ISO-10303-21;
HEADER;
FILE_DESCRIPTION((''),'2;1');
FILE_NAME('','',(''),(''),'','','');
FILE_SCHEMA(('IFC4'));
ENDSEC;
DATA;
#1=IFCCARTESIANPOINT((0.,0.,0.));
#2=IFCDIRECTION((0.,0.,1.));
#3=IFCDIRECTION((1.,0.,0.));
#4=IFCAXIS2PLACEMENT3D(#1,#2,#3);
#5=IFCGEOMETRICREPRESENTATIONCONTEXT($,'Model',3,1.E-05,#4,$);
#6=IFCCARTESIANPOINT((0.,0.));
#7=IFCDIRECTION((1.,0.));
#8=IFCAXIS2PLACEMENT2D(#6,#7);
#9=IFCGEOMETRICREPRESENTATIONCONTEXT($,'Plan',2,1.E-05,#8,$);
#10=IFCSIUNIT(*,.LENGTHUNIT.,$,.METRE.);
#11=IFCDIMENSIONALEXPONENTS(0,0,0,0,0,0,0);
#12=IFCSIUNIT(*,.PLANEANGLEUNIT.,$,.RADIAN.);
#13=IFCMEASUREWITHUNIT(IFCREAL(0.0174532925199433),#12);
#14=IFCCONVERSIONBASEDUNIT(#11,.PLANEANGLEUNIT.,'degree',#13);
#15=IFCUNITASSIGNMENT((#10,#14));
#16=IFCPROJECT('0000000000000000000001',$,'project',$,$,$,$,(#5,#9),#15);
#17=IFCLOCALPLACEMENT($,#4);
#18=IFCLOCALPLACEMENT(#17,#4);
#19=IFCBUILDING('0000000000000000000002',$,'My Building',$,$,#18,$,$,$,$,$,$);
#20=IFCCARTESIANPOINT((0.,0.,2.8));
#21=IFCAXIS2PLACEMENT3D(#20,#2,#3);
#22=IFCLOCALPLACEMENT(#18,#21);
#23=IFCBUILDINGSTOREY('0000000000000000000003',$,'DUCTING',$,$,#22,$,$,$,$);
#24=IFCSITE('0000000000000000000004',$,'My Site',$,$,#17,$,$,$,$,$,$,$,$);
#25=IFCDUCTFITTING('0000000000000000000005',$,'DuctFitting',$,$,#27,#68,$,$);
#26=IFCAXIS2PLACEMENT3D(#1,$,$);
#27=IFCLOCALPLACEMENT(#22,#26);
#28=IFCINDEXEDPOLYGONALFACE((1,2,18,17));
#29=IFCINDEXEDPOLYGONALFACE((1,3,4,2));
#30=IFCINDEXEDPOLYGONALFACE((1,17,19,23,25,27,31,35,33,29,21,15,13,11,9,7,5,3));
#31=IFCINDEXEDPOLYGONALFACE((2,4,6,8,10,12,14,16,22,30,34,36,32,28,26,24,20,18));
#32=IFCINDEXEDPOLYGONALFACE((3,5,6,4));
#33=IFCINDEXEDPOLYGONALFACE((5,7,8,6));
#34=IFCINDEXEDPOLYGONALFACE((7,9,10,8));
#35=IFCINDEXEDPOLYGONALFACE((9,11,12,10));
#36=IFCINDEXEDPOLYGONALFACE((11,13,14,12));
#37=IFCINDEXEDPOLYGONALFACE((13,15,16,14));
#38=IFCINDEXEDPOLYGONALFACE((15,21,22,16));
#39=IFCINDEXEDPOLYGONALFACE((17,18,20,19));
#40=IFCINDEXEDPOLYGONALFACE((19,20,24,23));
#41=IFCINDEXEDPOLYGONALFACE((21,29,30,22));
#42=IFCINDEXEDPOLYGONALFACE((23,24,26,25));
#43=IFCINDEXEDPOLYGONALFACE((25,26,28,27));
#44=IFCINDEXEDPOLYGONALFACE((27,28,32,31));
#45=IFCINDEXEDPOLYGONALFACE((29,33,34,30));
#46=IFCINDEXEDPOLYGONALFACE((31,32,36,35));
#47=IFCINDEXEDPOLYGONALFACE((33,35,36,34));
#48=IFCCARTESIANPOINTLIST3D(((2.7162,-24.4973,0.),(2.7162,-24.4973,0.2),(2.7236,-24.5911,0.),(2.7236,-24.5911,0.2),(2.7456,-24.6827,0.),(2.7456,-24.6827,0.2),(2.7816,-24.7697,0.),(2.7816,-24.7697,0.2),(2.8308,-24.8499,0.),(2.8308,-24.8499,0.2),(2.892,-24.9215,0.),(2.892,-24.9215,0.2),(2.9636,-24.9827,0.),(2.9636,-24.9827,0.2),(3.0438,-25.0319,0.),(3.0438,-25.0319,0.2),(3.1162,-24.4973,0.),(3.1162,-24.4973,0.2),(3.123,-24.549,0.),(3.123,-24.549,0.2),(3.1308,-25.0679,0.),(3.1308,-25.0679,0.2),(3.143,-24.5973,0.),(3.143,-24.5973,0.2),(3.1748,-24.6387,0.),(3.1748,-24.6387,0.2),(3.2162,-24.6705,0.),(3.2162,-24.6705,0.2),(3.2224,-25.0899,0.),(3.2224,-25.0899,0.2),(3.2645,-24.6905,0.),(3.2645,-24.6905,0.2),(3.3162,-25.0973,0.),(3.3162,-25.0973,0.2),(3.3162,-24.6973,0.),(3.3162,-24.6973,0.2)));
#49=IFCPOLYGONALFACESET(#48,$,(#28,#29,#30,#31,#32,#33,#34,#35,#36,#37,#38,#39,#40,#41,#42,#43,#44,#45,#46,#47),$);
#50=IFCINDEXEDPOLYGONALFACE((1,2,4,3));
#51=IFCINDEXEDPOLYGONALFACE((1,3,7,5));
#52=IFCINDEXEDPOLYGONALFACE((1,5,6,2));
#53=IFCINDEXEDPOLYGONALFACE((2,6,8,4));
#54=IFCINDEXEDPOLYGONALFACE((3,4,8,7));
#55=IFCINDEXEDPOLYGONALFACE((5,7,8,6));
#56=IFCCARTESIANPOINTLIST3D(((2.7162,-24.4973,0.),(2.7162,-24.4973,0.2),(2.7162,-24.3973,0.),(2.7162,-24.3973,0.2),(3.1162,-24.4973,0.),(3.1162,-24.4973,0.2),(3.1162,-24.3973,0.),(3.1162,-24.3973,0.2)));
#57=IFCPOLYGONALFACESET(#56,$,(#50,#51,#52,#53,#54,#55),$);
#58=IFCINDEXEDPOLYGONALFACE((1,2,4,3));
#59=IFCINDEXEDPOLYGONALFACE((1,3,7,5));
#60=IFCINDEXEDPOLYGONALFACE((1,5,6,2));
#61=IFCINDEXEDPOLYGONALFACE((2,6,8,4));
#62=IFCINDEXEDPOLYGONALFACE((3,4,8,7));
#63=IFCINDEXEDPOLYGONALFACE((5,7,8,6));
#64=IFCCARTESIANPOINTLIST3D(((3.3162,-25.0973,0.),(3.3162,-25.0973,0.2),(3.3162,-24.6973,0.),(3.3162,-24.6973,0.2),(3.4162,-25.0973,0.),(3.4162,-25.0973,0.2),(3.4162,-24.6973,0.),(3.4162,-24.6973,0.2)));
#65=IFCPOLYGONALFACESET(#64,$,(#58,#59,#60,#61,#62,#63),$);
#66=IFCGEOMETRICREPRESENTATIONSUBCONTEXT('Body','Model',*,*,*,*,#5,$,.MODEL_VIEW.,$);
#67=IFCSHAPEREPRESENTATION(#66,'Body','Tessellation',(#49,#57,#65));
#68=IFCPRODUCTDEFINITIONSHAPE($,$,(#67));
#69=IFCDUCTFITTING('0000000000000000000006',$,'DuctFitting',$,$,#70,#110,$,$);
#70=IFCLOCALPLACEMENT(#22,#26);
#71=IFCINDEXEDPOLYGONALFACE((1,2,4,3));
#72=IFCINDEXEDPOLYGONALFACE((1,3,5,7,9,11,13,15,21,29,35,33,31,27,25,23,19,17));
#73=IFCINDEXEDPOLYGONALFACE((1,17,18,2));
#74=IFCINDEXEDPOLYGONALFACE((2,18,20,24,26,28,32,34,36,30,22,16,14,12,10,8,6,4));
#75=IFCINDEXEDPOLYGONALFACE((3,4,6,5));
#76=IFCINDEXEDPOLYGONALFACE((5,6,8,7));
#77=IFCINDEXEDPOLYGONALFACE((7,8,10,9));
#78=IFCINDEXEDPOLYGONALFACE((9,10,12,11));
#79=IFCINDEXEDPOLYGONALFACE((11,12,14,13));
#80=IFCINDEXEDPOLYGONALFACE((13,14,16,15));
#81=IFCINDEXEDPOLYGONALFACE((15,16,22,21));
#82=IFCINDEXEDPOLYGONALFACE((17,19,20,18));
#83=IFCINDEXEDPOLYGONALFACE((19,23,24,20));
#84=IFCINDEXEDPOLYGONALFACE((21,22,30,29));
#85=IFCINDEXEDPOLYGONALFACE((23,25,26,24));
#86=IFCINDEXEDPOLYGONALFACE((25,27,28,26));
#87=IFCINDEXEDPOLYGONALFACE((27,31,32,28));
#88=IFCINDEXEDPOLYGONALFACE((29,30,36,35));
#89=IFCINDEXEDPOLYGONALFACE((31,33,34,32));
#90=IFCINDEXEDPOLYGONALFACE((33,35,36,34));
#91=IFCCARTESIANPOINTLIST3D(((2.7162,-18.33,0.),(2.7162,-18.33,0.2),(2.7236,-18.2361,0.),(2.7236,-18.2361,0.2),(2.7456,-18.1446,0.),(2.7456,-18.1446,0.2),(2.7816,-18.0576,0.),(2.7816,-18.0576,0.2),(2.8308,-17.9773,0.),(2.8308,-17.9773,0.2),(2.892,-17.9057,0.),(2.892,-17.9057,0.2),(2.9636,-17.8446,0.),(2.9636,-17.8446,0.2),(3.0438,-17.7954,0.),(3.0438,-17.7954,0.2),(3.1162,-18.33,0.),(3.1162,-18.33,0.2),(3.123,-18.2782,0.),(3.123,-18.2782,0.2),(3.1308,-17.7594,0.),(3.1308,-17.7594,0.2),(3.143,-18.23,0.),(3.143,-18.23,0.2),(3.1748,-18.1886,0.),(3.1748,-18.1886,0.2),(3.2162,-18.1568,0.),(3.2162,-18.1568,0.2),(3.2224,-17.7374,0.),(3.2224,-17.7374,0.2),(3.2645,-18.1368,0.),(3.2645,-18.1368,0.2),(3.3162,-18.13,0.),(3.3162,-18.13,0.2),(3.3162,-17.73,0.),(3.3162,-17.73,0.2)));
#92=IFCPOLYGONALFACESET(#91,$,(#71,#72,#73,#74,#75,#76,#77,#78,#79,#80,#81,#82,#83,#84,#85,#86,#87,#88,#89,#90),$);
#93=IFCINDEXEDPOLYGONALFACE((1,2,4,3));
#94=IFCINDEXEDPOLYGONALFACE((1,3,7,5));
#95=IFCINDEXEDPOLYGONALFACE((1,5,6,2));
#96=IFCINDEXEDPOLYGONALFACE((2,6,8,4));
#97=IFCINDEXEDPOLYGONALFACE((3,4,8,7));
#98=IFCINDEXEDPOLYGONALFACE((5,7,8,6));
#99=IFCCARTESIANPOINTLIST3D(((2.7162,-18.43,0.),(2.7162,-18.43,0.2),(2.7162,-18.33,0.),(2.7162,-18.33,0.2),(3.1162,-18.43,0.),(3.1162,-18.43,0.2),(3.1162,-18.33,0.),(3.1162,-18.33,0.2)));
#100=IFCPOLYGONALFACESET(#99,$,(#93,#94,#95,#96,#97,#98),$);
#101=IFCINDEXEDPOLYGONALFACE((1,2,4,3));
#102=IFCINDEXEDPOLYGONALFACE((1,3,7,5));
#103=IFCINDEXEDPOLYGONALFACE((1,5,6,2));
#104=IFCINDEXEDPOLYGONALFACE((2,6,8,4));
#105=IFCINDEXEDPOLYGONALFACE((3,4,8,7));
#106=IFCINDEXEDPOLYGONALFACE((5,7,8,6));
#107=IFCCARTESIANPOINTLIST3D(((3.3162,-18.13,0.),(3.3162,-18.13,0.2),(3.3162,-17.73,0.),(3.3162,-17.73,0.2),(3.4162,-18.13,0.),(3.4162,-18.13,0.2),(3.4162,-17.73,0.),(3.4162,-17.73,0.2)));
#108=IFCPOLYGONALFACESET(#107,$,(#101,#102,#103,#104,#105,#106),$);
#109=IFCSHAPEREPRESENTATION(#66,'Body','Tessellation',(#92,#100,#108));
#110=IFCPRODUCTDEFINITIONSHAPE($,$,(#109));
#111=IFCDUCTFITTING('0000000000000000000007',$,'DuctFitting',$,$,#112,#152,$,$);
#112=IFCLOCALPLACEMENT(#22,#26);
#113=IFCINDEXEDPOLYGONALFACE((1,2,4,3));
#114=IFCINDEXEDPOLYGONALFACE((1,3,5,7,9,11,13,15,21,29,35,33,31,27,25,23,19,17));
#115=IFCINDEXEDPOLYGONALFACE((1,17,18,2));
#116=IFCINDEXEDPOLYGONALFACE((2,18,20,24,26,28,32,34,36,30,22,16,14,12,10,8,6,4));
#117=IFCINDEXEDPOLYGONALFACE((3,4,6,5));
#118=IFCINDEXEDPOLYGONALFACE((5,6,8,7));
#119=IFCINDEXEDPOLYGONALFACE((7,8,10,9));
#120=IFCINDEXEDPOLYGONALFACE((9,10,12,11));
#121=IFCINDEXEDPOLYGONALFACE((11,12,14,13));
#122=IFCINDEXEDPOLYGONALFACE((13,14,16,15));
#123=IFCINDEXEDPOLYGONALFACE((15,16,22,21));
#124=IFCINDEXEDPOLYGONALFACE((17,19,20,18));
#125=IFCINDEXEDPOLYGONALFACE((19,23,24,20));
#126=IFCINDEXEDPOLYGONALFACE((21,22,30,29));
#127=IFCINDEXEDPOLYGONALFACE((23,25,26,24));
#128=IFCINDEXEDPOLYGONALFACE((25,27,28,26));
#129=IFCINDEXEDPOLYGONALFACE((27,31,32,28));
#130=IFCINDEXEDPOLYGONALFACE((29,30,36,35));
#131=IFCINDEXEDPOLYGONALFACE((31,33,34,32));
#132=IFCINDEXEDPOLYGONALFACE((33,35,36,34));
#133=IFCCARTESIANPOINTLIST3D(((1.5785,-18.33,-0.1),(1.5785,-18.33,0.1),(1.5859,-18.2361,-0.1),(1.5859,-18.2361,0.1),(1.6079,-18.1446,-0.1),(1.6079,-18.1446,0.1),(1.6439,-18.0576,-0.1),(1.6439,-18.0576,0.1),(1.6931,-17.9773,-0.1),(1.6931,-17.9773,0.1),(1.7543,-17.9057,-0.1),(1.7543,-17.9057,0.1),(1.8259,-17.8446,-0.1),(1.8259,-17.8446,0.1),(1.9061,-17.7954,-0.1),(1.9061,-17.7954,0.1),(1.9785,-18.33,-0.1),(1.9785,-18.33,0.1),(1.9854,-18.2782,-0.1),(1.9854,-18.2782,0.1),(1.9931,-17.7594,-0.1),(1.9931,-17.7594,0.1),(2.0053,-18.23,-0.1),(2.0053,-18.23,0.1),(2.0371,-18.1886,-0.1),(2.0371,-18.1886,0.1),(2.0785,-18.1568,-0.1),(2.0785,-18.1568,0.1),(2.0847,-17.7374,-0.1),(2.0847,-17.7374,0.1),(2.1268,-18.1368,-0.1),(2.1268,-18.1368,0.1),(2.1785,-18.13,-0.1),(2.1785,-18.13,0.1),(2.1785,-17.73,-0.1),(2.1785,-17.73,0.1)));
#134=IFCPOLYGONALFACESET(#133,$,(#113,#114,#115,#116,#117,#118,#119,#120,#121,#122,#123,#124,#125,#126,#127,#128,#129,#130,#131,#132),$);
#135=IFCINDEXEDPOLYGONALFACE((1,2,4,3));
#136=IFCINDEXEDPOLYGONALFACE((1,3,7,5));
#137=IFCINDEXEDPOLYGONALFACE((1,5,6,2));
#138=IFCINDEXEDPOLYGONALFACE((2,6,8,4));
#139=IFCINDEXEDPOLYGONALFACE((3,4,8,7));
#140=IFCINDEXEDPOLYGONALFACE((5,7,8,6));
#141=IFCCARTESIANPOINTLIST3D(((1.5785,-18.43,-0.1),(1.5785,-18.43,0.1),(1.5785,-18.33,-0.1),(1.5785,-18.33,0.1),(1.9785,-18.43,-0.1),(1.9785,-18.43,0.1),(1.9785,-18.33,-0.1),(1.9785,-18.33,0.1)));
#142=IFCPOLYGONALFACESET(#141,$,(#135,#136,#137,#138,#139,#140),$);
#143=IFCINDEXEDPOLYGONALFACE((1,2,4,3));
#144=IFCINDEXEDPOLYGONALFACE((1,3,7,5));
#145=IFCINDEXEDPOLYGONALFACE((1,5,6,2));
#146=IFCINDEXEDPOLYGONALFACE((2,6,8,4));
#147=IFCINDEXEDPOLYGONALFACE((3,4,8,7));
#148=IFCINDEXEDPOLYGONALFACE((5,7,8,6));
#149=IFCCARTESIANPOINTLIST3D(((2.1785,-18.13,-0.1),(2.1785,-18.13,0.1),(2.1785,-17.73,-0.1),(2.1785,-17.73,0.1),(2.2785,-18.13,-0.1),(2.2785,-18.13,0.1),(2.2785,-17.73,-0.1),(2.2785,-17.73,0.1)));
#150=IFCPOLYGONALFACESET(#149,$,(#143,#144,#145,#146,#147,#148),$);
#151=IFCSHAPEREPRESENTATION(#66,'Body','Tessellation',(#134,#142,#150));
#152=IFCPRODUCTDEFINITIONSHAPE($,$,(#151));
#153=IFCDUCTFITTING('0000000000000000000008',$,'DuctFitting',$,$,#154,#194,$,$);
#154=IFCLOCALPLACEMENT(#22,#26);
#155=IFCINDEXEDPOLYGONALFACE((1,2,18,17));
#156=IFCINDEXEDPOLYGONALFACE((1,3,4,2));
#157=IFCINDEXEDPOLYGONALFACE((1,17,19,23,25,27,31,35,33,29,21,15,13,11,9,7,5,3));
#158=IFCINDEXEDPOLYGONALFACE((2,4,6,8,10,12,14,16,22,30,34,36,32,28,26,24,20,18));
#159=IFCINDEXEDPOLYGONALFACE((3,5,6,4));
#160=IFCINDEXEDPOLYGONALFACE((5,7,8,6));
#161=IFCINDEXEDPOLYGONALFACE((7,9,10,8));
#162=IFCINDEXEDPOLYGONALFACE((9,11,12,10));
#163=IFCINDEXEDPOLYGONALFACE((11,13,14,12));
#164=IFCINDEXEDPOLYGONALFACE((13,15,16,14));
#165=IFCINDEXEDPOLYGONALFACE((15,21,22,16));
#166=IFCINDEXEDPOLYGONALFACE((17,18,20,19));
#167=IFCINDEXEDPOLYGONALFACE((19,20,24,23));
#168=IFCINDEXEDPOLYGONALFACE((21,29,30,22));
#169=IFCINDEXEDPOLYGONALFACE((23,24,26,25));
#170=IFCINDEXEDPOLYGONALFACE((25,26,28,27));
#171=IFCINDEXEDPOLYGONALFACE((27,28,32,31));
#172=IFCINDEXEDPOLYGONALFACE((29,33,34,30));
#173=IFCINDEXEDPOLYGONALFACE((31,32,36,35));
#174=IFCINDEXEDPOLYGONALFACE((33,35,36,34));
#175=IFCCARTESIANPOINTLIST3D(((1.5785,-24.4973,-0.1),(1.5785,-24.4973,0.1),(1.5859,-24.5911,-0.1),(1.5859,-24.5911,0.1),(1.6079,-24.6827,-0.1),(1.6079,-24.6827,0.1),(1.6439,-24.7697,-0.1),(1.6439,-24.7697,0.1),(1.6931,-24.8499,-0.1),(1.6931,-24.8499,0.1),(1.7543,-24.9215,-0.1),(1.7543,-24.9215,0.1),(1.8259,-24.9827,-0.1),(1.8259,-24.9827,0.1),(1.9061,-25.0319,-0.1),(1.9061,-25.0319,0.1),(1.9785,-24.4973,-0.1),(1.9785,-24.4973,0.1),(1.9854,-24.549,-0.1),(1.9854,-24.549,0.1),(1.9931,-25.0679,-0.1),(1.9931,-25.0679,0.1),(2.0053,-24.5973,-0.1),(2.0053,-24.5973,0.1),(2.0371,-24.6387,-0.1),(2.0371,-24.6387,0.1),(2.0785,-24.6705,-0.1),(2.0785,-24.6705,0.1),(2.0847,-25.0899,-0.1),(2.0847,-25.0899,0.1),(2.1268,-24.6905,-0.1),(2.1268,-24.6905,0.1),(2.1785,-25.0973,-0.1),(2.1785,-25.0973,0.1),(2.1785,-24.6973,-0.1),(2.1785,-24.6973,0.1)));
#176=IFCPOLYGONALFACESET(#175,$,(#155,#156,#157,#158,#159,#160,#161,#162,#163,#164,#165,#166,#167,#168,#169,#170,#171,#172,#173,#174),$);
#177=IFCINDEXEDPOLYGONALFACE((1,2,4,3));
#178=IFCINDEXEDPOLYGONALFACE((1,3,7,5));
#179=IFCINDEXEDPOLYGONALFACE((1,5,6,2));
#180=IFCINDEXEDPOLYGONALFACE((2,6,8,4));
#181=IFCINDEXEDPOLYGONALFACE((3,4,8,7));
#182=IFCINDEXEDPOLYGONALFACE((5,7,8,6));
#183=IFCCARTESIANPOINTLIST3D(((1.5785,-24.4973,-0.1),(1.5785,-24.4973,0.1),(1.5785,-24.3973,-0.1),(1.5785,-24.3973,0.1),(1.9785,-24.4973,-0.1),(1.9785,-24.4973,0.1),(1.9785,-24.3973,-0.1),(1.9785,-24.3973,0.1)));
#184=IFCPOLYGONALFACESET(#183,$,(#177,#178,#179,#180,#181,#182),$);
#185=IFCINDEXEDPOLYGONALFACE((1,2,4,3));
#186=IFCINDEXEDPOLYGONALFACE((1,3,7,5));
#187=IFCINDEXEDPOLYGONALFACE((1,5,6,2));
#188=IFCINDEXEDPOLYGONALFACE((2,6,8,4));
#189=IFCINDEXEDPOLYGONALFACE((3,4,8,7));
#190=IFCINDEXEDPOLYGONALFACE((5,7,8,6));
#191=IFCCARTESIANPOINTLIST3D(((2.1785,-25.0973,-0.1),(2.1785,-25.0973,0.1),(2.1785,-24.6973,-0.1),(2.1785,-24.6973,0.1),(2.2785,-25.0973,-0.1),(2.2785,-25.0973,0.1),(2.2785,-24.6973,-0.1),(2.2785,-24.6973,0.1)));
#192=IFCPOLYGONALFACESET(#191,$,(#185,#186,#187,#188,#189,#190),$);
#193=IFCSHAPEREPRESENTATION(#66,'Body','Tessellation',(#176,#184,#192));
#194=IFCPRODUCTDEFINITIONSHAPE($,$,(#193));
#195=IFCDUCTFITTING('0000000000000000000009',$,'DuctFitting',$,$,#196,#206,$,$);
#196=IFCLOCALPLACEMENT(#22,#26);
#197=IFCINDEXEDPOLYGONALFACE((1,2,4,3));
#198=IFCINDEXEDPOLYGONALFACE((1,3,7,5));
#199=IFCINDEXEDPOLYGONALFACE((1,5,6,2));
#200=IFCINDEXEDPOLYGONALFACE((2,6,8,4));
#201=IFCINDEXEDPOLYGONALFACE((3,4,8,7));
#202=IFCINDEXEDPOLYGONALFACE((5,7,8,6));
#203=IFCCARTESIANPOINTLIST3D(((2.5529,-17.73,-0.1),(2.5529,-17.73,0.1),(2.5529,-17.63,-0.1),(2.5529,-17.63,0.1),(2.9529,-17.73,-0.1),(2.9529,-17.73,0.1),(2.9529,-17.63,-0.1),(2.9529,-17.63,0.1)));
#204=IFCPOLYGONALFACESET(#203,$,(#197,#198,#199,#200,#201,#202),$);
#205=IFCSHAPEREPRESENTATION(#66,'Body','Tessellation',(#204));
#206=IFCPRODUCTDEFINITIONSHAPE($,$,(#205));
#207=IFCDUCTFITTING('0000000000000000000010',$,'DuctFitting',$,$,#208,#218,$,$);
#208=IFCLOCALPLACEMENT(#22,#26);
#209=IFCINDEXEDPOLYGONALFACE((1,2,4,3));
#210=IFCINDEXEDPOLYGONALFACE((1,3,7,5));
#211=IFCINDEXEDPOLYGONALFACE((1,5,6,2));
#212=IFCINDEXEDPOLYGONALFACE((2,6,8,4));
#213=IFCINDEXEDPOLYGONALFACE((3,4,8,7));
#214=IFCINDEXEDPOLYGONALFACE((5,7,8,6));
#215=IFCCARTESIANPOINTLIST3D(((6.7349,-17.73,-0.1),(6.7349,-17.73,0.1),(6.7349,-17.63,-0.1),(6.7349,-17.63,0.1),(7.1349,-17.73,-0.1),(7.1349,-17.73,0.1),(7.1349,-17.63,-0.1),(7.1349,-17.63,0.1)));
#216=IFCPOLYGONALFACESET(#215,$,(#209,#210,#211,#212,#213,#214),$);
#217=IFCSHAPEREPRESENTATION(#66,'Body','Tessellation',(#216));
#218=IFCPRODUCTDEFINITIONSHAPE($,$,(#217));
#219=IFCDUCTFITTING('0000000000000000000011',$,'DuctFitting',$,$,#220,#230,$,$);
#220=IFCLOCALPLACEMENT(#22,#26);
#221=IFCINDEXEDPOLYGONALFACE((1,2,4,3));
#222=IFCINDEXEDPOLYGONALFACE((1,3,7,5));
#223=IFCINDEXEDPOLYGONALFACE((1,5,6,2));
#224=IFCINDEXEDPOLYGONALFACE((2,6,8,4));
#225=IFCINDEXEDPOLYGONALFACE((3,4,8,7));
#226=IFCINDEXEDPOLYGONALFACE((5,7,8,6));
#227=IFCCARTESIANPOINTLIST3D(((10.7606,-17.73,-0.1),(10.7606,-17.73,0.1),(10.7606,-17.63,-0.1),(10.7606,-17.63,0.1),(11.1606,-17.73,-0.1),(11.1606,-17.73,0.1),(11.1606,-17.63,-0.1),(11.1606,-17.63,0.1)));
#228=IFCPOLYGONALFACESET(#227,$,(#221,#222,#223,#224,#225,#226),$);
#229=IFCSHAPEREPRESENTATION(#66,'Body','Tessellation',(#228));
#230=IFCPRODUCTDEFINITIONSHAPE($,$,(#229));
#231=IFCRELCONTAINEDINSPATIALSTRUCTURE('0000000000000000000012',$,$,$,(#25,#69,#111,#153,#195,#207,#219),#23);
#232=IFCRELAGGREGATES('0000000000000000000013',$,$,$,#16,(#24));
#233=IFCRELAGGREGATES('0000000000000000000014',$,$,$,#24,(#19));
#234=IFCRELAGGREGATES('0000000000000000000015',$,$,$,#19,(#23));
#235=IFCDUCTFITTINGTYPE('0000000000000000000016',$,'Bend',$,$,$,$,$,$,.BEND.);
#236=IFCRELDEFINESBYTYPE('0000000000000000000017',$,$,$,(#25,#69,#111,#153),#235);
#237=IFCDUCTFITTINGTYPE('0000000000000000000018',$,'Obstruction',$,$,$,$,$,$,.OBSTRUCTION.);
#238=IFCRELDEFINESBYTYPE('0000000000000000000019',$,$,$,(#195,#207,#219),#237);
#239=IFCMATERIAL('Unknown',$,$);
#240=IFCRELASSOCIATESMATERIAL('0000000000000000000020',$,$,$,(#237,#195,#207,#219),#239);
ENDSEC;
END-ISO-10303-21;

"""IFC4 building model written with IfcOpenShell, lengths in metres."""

from ifc_helpers import new_model, entity, si_unit, converted_unit, frame, origin_with_axes, origin_2d_with_axis, place, context, subcontext, project, spatial, line, arc, indexed_curve, rectangle, outline, extrude, source, transform, mapped, material, material_profile, profile_set, profile_usage, type_object, type_shapes, element, save


model = new_model("IFC4")

# Units and contexts
model_context = context("Model", 3, precision=1e-05, world=origin_with_axes())
plan_context = context("Plan", 2, precision=1e-05, world=origin_2d_with_axis())
body_context = subcontext(model_context, "Body", "Model", "MODEL_VIEW")
ifc_project = project(units=[si_unit("LENGTHUNIT", "METRE"), converted_unit("PLANEANGLEUNIT", "degree", entity("IfcReal", 0.0174532925199433), si_unit("PLANEANGLEUNIT", "RADIAN"), dimensions=[0, 0, 0, 0, 0, 0, 0])], contexts=[model_context, plan_context])

# Site, building, storey
site_placement = place(None, origin_with_axes())
site = spatial("IfcSite", under=ifc_project, at=site_placement, Name="My Site")
building_placement = place(site_placement, origin_with_axes())
building = spatial("IfcBuilding", under=site, at=building_placement, Name="My Building")
storey_placement = place(building_placement, frame((0.0, 0.0, 2.8), z_axis=(0.0, 0.0, 1.0), x_axis=(1.0, 0.0, 0.0)))
storey = spatial("IfcBuildingStorey", under=building, at=storey_placement, Name="DUCTING")

# Shared definitions
ifc_material = material(Name="Unknown")

# Duct fittings
duct_fitting_type_1 = type_object("IfcDuctFittingType", Name="Bend", PredefinedType="BEND")
shared_shape = source(origin_with_axes(), body_context, "Body", "SweptSolid", [
    extrude(outline(indexed_curve([(0.2, 0.0), (0.2586, 0.1414), (0.4, 0.2), (0.4, 0.6), (-0.0243, 0.4243), (-0.2, 0.0)], segments=[arc(1, 2, 3), line(3, 4), arc(4, 5, 6), line(6, 1)])), frame((0.0, -0.1, 0.1), z_axis=(0.0, -1.0, 0.0), x_axis=(1.0, 0.0, 0.0)), (0.0, 0.0, -1.0), 0.2),
    extrude(rectangle(XDim=0.4, YDim=0.2), origin_with_axes(), (0.0, 0.0, 1.0), 0.1),
    extrude(rectangle(XDim=0.4, YDim=0.2), frame((0.4, 0.0, 0.5), z_axis=(1.0, 0.0, 0.0), x_axis=(0.0, 0.0, 1.0)), (0.0, 0.0, 1.0), 0.1),
])
type_shapes(duct_fitting_type_1, [shared_shape])
for number, where, z_axis, x_axis, name in (
    (1, (2.9162, -24.3973, 0.1), (0.0, -1.0, 0.0), (1.0, 0.0, 0.0), "DuctFitting"),
    (2, (2.9162, -18.43, 0.1), (0.0, 1.0, 0.0), (1.0, 0.0, 0.0), "DuctFitting"),
    (3, (1.7785, -18.43, 0.0), (0.0, 1.0, 0.0), (1.0, 0.0, 0.0), "DuctFitting"),
    (4, (1.7785, -24.3973, 0.0), (0.0, -1.0, 0.0), (1.0, 0.0, 0.0), "DuctFitting"),
):
    element("IfcDuctFitting", number, at=place(storey_placement, frame(where, z_axis=z_axis, x_axis=x_axis)), inside=storey, type_object=duct_fitting_type_1, Name=name, context=body_context, shape_type="MappedRepresentation", body=[
        mapped(shared_shape, transform((0.0, 0.0, 0.0), x_axis=(1.0, 0.0, 0.0), y_axis=(0.0, 1.0, 0.0), z_axis=(0.0, 0.0, 1.0), scale=1.0)),
    ])
ifc_material_profile_1 = material_profile(ifc_material, rectangle(XDim=0.4, YDim=0.2))
ifc_profile_set_1 = profile_set([ifc_material_profile_1])
ifc_profile_usage_1 = profile_usage(ifc_profile_set_1, cardinal=5)
duct_fitting_type_2 = type_object("IfcDuctFittingType", Name="Obstruction", PredefinedType="OBSTRUCTION", material=ifc_profile_set_1)
duct_fitting_1_placement = place(storey_placement, frame((2.7529, -17.73, 0.0), z_axis=(0.0, 1.0, 0.0), x_axis=(-1.0, 0.0, 0.0)))
element("IfcDuctFitting", 5, at=duct_fitting_1_placement, inside=storey, type_object=duct_fitting_type_2, material=ifc_profile_usage_1, Name="DuctFitting", context=body_context, shape_type="SweptSolid", body=[
    extrude(rectangle(XDim=0.4, YDim=0.2), origin_with_axes(), (0.0, 0.0, 1.0), 0.1),
])
ifc_profile_usage_2 = profile_usage(ifc_profile_set_1, cardinal=5)
duct_fitting_2_placement = place(storey_placement, frame((6.9349, -17.73, 0.0), z_axis=(0.0, 1.0, 0.0), x_axis=(-1.0, 0.0, 0.0)))
element("IfcDuctFitting", 6, at=duct_fitting_2_placement, inside=storey, type_object=duct_fitting_type_2, material=ifc_profile_usage_2, Name="DuctFitting", context=body_context, shape_type="SweptSolid", body=[
    extrude(rectangle(XDim=0.4, YDim=0.2), origin_with_axes(), (0.0, 0.0, 1.0), 0.1),
])
ifc_profile_usage_3 = profile_usage(ifc_profile_set_1, cardinal=5)
duct_fitting_3_placement = place(storey_placement, frame((10.9606, -17.73, 0.0), z_axis=(0.0, 1.0, 0.0), x_axis=(-1.0, 0.0, 0.0)))
element("IfcDuctFitting", 7, at=duct_fitting_3_placement, inside=storey, type_object=duct_fitting_type_2, material=ifc_profile_usage_3, Name="DuctFitting", context=body_context, shape_type="SweptSolid", body=[
    extrude(rectangle(XDim=0.4, YDim=0.2), origin_with_axes(), (0.0, 0.0, 1.0), 0.1),
])

save(model, "model.ifc")
